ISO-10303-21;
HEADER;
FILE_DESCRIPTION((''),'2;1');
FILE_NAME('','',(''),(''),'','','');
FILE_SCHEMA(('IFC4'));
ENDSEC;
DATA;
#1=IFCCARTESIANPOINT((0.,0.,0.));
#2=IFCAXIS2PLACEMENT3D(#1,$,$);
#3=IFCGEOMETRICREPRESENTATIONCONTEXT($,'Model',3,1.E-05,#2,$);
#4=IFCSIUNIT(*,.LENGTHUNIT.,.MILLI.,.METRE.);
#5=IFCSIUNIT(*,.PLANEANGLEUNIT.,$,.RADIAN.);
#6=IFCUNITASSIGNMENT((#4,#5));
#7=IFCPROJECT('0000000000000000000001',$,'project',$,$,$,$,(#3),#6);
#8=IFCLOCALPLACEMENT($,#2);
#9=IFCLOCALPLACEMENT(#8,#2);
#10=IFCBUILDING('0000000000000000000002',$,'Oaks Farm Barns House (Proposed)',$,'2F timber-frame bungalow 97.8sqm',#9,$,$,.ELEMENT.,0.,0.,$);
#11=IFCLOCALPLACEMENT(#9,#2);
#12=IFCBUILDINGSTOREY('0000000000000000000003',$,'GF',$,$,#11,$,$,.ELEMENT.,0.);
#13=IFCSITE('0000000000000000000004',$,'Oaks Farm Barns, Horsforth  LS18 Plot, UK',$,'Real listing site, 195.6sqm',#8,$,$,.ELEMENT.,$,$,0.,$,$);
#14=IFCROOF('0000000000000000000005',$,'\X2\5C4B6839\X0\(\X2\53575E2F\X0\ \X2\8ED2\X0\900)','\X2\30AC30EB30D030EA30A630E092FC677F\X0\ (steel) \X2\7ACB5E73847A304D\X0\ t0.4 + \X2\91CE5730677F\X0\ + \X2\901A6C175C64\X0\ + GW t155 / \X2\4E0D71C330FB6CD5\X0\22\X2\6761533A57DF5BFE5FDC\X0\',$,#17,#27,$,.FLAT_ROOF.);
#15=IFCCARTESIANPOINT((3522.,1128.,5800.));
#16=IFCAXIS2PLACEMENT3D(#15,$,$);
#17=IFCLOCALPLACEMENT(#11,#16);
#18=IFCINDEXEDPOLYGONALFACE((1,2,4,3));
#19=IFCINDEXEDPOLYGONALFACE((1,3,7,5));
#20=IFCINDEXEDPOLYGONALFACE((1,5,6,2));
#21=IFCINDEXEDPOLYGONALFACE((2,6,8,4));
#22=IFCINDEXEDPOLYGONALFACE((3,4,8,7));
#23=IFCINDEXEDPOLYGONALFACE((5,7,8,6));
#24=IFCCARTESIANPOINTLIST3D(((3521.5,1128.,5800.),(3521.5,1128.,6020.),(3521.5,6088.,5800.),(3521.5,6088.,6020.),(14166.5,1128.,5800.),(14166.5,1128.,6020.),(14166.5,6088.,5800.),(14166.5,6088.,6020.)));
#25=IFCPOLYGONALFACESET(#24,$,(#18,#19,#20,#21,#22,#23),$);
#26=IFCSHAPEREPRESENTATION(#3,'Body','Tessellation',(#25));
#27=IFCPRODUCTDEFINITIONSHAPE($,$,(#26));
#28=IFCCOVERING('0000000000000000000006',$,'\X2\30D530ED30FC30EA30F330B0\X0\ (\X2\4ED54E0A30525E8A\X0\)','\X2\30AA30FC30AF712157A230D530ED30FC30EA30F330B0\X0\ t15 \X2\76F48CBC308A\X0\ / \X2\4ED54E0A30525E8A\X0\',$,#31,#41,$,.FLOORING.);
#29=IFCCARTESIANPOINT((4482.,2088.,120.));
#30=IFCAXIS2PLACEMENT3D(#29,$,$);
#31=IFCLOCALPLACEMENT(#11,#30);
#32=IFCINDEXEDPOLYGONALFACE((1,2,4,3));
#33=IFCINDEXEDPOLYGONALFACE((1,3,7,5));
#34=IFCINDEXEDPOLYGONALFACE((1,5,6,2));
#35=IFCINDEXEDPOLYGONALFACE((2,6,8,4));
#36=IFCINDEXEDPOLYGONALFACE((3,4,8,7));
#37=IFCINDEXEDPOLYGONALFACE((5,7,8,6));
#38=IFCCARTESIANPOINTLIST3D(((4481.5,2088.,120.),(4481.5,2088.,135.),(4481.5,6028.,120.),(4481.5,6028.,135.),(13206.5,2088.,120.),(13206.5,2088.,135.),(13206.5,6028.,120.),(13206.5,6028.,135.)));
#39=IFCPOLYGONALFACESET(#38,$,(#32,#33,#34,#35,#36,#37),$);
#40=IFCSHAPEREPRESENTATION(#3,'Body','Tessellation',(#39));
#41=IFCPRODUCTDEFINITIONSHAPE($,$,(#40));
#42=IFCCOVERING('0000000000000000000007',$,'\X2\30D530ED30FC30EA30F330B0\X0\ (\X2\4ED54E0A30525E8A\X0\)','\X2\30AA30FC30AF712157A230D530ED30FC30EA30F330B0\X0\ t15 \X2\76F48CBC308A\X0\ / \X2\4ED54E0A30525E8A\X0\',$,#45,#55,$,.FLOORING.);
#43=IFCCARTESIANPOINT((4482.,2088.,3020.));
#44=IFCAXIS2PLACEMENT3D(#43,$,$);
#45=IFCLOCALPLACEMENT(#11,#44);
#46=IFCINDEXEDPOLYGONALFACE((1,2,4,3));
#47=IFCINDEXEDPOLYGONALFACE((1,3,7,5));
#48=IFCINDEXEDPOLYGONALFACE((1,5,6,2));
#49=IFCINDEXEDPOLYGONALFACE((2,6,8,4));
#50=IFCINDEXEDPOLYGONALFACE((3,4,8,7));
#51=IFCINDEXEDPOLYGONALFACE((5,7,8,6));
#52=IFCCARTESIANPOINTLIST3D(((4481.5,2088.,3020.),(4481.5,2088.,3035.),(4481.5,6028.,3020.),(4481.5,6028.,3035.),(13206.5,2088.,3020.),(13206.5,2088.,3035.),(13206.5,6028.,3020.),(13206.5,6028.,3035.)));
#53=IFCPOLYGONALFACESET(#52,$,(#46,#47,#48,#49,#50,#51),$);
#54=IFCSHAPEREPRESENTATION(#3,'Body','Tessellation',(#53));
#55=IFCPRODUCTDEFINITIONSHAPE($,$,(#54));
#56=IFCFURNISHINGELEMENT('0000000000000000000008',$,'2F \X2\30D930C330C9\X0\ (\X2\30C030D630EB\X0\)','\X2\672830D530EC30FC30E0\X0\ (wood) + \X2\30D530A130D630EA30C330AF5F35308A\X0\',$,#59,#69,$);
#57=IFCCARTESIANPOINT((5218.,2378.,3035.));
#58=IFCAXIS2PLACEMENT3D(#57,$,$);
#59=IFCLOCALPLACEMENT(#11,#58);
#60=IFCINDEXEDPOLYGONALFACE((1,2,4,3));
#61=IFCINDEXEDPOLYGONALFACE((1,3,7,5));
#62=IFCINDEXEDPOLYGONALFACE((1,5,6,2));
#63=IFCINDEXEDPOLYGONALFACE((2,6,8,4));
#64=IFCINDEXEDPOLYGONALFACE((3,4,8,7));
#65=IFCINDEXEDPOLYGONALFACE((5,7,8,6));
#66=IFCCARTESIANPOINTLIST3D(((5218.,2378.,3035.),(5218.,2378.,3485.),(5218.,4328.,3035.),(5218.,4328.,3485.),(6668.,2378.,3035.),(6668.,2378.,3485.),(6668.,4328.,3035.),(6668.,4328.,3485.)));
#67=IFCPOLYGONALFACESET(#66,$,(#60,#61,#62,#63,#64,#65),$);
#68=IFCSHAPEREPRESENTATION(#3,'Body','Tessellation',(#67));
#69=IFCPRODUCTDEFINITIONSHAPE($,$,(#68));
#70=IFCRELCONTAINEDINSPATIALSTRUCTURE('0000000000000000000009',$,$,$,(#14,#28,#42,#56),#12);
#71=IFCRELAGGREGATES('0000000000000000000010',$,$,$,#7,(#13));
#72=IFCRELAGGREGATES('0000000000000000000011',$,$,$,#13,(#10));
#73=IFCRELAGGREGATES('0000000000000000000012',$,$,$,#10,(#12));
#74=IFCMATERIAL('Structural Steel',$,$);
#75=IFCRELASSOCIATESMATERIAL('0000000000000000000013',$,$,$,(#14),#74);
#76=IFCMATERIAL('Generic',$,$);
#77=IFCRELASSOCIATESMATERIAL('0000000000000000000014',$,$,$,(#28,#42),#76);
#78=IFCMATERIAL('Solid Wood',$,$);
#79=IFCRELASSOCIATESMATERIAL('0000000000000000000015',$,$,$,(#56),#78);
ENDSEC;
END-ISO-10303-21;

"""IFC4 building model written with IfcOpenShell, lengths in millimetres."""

from ifc_helpers import new_model, si_unit, frame, frame_2d, origin, place, context, project, spatial, rectangle, extrude, material, element, save


model = new_model("IFC4")

# Units and contexts
model_context = context("Model", 3, precision=1e-05, world=origin())
ifc_project = project(units=[si_unit("LENGTHUNIT", "METRE", prefix="MILLI"), si_unit("PLANEANGLEUNIT", "RADIAN")], contexts=[model_context])

# Site, building, storey
site_placement = place(None, origin())
site = spatial("IfcSite", under=ifc_project, at=site_placement, Name="Oaks Farm Barns, Horsforth  LS18 Plot, UK", ObjectType="Real listing site, 195.6sqm", CompositionType="ELEMENT", RefElevation=0.0)
building_placement = place(site_placement, origin())
building = spatial("IfcBuilding", under=site, at=building_placement, Name="Oaks Farm Barns House (Proposed)", ObjectType="2F timber-frame bungalow 97.8sqm", CompositionType="ELEMENT", ElevationOfRefHeight=0.0, ElevationOfTerrain=0.0)
storey_placement = place(building_placement, origin())
storey = spatial("IfcBuildingStorey", under=building, at=storey_placement, Name="GF", CompositionType="ELEMENT", Elevation=0.0)

# Shared definitions
ifc_material_1 = material(Name="Solid Wood")

# Roof
ifc_material_2 = material(Name="Structural Steel")
for number, where, name in (
    (1, (3522.0, 1128.0, 5800.0), "屋根(南帯 軒900)"),
):
    element("IfcRoof", number, at=place(storey_placement, frame(where)), inside=storey, material=ifc_material_2, Name=name, Description="ガルバリウム鋼板 (steel) 立平葺き t0.4 + 野地板 + 通気層 + GW t155 / 不燃・法22条区域対応", PredefinedType="FLAT_ROOF", context=model_context, shape_type="SweptSolid", body=[
        extrude(rectangle(XDim=10645.0, YDim=4960.0, at=frame_2d((5322.0, 2480.0))), frame((3522.0, 1128.0, 5800.0)), (0.0, 0.0, 1.0), 220.0),
    ])

# Coverings
ifc_material_3 = material(Name="Generic")
covering_1_placement = place(storey_placement, frame((4482.0, 2088.0, 120.0)))
element("IfcCovering", 2, at=covering_1_placement, inside=storey, material=ifc_material_3, Name="フローリング (仕上げ床)", Description="オーク無垢フローリング t15 直貼り / 仕上げ床", PredefinedType="FLOORING", context=model_context, shape_type="SweptSolid", body=[
    extrude(rectangle(XDim=8725.0, YDim=3940.0, at=frame_2d((4362.0, 1970.0))), frame((4482.0, 2088.0, 120.0)), (0.0, 0.0, 1.0), 15.0),
])
covering_2_placement = place(storey_placement, frame((4482.0, 2088.0, 3020.0)))
element("IfcCovering", 3, at=covering_2_placement, inside=storey, material=ifc_material_3, Name="フローリング (仕上げ床)", Description="オーク無垢フローリング t15 直貼り / 仕上げ床", PredefinedType="FLOORING", context=model_context, shape_type="SweptSolid", body=[
    extrude(rectangle(XDim=8725.0, YDim=3940.0, at=frame_2d((4362.0, 1970.0))), frame((4482.0, 2088.0, 3020.0)), (0.0, 0.0, 1.0), 15.0),
])

# Furnishing element
furnishing_placement = place(storey_placement, frame((5218.0, 2378.0, 3035.0)))
element("IfcFurnishingElement", 4, at=furnishing_placement, inside=storey, material=ifc_material_1, Name="2F ベッド (ダブル)", Description="木フレーム (wood) + ファブリック張り", context=model_context, shape_type="SweptSolid", body=[
    extrude(rectangle(XDim=1450.0, YDim=1950.0, at=frame_2d((725.0, 975.0))), frame((5218.0, 2378.0, 3035.0)), (0.0, 0.0, 1.0), 450.0),
])

save(model, "model.ifc")
